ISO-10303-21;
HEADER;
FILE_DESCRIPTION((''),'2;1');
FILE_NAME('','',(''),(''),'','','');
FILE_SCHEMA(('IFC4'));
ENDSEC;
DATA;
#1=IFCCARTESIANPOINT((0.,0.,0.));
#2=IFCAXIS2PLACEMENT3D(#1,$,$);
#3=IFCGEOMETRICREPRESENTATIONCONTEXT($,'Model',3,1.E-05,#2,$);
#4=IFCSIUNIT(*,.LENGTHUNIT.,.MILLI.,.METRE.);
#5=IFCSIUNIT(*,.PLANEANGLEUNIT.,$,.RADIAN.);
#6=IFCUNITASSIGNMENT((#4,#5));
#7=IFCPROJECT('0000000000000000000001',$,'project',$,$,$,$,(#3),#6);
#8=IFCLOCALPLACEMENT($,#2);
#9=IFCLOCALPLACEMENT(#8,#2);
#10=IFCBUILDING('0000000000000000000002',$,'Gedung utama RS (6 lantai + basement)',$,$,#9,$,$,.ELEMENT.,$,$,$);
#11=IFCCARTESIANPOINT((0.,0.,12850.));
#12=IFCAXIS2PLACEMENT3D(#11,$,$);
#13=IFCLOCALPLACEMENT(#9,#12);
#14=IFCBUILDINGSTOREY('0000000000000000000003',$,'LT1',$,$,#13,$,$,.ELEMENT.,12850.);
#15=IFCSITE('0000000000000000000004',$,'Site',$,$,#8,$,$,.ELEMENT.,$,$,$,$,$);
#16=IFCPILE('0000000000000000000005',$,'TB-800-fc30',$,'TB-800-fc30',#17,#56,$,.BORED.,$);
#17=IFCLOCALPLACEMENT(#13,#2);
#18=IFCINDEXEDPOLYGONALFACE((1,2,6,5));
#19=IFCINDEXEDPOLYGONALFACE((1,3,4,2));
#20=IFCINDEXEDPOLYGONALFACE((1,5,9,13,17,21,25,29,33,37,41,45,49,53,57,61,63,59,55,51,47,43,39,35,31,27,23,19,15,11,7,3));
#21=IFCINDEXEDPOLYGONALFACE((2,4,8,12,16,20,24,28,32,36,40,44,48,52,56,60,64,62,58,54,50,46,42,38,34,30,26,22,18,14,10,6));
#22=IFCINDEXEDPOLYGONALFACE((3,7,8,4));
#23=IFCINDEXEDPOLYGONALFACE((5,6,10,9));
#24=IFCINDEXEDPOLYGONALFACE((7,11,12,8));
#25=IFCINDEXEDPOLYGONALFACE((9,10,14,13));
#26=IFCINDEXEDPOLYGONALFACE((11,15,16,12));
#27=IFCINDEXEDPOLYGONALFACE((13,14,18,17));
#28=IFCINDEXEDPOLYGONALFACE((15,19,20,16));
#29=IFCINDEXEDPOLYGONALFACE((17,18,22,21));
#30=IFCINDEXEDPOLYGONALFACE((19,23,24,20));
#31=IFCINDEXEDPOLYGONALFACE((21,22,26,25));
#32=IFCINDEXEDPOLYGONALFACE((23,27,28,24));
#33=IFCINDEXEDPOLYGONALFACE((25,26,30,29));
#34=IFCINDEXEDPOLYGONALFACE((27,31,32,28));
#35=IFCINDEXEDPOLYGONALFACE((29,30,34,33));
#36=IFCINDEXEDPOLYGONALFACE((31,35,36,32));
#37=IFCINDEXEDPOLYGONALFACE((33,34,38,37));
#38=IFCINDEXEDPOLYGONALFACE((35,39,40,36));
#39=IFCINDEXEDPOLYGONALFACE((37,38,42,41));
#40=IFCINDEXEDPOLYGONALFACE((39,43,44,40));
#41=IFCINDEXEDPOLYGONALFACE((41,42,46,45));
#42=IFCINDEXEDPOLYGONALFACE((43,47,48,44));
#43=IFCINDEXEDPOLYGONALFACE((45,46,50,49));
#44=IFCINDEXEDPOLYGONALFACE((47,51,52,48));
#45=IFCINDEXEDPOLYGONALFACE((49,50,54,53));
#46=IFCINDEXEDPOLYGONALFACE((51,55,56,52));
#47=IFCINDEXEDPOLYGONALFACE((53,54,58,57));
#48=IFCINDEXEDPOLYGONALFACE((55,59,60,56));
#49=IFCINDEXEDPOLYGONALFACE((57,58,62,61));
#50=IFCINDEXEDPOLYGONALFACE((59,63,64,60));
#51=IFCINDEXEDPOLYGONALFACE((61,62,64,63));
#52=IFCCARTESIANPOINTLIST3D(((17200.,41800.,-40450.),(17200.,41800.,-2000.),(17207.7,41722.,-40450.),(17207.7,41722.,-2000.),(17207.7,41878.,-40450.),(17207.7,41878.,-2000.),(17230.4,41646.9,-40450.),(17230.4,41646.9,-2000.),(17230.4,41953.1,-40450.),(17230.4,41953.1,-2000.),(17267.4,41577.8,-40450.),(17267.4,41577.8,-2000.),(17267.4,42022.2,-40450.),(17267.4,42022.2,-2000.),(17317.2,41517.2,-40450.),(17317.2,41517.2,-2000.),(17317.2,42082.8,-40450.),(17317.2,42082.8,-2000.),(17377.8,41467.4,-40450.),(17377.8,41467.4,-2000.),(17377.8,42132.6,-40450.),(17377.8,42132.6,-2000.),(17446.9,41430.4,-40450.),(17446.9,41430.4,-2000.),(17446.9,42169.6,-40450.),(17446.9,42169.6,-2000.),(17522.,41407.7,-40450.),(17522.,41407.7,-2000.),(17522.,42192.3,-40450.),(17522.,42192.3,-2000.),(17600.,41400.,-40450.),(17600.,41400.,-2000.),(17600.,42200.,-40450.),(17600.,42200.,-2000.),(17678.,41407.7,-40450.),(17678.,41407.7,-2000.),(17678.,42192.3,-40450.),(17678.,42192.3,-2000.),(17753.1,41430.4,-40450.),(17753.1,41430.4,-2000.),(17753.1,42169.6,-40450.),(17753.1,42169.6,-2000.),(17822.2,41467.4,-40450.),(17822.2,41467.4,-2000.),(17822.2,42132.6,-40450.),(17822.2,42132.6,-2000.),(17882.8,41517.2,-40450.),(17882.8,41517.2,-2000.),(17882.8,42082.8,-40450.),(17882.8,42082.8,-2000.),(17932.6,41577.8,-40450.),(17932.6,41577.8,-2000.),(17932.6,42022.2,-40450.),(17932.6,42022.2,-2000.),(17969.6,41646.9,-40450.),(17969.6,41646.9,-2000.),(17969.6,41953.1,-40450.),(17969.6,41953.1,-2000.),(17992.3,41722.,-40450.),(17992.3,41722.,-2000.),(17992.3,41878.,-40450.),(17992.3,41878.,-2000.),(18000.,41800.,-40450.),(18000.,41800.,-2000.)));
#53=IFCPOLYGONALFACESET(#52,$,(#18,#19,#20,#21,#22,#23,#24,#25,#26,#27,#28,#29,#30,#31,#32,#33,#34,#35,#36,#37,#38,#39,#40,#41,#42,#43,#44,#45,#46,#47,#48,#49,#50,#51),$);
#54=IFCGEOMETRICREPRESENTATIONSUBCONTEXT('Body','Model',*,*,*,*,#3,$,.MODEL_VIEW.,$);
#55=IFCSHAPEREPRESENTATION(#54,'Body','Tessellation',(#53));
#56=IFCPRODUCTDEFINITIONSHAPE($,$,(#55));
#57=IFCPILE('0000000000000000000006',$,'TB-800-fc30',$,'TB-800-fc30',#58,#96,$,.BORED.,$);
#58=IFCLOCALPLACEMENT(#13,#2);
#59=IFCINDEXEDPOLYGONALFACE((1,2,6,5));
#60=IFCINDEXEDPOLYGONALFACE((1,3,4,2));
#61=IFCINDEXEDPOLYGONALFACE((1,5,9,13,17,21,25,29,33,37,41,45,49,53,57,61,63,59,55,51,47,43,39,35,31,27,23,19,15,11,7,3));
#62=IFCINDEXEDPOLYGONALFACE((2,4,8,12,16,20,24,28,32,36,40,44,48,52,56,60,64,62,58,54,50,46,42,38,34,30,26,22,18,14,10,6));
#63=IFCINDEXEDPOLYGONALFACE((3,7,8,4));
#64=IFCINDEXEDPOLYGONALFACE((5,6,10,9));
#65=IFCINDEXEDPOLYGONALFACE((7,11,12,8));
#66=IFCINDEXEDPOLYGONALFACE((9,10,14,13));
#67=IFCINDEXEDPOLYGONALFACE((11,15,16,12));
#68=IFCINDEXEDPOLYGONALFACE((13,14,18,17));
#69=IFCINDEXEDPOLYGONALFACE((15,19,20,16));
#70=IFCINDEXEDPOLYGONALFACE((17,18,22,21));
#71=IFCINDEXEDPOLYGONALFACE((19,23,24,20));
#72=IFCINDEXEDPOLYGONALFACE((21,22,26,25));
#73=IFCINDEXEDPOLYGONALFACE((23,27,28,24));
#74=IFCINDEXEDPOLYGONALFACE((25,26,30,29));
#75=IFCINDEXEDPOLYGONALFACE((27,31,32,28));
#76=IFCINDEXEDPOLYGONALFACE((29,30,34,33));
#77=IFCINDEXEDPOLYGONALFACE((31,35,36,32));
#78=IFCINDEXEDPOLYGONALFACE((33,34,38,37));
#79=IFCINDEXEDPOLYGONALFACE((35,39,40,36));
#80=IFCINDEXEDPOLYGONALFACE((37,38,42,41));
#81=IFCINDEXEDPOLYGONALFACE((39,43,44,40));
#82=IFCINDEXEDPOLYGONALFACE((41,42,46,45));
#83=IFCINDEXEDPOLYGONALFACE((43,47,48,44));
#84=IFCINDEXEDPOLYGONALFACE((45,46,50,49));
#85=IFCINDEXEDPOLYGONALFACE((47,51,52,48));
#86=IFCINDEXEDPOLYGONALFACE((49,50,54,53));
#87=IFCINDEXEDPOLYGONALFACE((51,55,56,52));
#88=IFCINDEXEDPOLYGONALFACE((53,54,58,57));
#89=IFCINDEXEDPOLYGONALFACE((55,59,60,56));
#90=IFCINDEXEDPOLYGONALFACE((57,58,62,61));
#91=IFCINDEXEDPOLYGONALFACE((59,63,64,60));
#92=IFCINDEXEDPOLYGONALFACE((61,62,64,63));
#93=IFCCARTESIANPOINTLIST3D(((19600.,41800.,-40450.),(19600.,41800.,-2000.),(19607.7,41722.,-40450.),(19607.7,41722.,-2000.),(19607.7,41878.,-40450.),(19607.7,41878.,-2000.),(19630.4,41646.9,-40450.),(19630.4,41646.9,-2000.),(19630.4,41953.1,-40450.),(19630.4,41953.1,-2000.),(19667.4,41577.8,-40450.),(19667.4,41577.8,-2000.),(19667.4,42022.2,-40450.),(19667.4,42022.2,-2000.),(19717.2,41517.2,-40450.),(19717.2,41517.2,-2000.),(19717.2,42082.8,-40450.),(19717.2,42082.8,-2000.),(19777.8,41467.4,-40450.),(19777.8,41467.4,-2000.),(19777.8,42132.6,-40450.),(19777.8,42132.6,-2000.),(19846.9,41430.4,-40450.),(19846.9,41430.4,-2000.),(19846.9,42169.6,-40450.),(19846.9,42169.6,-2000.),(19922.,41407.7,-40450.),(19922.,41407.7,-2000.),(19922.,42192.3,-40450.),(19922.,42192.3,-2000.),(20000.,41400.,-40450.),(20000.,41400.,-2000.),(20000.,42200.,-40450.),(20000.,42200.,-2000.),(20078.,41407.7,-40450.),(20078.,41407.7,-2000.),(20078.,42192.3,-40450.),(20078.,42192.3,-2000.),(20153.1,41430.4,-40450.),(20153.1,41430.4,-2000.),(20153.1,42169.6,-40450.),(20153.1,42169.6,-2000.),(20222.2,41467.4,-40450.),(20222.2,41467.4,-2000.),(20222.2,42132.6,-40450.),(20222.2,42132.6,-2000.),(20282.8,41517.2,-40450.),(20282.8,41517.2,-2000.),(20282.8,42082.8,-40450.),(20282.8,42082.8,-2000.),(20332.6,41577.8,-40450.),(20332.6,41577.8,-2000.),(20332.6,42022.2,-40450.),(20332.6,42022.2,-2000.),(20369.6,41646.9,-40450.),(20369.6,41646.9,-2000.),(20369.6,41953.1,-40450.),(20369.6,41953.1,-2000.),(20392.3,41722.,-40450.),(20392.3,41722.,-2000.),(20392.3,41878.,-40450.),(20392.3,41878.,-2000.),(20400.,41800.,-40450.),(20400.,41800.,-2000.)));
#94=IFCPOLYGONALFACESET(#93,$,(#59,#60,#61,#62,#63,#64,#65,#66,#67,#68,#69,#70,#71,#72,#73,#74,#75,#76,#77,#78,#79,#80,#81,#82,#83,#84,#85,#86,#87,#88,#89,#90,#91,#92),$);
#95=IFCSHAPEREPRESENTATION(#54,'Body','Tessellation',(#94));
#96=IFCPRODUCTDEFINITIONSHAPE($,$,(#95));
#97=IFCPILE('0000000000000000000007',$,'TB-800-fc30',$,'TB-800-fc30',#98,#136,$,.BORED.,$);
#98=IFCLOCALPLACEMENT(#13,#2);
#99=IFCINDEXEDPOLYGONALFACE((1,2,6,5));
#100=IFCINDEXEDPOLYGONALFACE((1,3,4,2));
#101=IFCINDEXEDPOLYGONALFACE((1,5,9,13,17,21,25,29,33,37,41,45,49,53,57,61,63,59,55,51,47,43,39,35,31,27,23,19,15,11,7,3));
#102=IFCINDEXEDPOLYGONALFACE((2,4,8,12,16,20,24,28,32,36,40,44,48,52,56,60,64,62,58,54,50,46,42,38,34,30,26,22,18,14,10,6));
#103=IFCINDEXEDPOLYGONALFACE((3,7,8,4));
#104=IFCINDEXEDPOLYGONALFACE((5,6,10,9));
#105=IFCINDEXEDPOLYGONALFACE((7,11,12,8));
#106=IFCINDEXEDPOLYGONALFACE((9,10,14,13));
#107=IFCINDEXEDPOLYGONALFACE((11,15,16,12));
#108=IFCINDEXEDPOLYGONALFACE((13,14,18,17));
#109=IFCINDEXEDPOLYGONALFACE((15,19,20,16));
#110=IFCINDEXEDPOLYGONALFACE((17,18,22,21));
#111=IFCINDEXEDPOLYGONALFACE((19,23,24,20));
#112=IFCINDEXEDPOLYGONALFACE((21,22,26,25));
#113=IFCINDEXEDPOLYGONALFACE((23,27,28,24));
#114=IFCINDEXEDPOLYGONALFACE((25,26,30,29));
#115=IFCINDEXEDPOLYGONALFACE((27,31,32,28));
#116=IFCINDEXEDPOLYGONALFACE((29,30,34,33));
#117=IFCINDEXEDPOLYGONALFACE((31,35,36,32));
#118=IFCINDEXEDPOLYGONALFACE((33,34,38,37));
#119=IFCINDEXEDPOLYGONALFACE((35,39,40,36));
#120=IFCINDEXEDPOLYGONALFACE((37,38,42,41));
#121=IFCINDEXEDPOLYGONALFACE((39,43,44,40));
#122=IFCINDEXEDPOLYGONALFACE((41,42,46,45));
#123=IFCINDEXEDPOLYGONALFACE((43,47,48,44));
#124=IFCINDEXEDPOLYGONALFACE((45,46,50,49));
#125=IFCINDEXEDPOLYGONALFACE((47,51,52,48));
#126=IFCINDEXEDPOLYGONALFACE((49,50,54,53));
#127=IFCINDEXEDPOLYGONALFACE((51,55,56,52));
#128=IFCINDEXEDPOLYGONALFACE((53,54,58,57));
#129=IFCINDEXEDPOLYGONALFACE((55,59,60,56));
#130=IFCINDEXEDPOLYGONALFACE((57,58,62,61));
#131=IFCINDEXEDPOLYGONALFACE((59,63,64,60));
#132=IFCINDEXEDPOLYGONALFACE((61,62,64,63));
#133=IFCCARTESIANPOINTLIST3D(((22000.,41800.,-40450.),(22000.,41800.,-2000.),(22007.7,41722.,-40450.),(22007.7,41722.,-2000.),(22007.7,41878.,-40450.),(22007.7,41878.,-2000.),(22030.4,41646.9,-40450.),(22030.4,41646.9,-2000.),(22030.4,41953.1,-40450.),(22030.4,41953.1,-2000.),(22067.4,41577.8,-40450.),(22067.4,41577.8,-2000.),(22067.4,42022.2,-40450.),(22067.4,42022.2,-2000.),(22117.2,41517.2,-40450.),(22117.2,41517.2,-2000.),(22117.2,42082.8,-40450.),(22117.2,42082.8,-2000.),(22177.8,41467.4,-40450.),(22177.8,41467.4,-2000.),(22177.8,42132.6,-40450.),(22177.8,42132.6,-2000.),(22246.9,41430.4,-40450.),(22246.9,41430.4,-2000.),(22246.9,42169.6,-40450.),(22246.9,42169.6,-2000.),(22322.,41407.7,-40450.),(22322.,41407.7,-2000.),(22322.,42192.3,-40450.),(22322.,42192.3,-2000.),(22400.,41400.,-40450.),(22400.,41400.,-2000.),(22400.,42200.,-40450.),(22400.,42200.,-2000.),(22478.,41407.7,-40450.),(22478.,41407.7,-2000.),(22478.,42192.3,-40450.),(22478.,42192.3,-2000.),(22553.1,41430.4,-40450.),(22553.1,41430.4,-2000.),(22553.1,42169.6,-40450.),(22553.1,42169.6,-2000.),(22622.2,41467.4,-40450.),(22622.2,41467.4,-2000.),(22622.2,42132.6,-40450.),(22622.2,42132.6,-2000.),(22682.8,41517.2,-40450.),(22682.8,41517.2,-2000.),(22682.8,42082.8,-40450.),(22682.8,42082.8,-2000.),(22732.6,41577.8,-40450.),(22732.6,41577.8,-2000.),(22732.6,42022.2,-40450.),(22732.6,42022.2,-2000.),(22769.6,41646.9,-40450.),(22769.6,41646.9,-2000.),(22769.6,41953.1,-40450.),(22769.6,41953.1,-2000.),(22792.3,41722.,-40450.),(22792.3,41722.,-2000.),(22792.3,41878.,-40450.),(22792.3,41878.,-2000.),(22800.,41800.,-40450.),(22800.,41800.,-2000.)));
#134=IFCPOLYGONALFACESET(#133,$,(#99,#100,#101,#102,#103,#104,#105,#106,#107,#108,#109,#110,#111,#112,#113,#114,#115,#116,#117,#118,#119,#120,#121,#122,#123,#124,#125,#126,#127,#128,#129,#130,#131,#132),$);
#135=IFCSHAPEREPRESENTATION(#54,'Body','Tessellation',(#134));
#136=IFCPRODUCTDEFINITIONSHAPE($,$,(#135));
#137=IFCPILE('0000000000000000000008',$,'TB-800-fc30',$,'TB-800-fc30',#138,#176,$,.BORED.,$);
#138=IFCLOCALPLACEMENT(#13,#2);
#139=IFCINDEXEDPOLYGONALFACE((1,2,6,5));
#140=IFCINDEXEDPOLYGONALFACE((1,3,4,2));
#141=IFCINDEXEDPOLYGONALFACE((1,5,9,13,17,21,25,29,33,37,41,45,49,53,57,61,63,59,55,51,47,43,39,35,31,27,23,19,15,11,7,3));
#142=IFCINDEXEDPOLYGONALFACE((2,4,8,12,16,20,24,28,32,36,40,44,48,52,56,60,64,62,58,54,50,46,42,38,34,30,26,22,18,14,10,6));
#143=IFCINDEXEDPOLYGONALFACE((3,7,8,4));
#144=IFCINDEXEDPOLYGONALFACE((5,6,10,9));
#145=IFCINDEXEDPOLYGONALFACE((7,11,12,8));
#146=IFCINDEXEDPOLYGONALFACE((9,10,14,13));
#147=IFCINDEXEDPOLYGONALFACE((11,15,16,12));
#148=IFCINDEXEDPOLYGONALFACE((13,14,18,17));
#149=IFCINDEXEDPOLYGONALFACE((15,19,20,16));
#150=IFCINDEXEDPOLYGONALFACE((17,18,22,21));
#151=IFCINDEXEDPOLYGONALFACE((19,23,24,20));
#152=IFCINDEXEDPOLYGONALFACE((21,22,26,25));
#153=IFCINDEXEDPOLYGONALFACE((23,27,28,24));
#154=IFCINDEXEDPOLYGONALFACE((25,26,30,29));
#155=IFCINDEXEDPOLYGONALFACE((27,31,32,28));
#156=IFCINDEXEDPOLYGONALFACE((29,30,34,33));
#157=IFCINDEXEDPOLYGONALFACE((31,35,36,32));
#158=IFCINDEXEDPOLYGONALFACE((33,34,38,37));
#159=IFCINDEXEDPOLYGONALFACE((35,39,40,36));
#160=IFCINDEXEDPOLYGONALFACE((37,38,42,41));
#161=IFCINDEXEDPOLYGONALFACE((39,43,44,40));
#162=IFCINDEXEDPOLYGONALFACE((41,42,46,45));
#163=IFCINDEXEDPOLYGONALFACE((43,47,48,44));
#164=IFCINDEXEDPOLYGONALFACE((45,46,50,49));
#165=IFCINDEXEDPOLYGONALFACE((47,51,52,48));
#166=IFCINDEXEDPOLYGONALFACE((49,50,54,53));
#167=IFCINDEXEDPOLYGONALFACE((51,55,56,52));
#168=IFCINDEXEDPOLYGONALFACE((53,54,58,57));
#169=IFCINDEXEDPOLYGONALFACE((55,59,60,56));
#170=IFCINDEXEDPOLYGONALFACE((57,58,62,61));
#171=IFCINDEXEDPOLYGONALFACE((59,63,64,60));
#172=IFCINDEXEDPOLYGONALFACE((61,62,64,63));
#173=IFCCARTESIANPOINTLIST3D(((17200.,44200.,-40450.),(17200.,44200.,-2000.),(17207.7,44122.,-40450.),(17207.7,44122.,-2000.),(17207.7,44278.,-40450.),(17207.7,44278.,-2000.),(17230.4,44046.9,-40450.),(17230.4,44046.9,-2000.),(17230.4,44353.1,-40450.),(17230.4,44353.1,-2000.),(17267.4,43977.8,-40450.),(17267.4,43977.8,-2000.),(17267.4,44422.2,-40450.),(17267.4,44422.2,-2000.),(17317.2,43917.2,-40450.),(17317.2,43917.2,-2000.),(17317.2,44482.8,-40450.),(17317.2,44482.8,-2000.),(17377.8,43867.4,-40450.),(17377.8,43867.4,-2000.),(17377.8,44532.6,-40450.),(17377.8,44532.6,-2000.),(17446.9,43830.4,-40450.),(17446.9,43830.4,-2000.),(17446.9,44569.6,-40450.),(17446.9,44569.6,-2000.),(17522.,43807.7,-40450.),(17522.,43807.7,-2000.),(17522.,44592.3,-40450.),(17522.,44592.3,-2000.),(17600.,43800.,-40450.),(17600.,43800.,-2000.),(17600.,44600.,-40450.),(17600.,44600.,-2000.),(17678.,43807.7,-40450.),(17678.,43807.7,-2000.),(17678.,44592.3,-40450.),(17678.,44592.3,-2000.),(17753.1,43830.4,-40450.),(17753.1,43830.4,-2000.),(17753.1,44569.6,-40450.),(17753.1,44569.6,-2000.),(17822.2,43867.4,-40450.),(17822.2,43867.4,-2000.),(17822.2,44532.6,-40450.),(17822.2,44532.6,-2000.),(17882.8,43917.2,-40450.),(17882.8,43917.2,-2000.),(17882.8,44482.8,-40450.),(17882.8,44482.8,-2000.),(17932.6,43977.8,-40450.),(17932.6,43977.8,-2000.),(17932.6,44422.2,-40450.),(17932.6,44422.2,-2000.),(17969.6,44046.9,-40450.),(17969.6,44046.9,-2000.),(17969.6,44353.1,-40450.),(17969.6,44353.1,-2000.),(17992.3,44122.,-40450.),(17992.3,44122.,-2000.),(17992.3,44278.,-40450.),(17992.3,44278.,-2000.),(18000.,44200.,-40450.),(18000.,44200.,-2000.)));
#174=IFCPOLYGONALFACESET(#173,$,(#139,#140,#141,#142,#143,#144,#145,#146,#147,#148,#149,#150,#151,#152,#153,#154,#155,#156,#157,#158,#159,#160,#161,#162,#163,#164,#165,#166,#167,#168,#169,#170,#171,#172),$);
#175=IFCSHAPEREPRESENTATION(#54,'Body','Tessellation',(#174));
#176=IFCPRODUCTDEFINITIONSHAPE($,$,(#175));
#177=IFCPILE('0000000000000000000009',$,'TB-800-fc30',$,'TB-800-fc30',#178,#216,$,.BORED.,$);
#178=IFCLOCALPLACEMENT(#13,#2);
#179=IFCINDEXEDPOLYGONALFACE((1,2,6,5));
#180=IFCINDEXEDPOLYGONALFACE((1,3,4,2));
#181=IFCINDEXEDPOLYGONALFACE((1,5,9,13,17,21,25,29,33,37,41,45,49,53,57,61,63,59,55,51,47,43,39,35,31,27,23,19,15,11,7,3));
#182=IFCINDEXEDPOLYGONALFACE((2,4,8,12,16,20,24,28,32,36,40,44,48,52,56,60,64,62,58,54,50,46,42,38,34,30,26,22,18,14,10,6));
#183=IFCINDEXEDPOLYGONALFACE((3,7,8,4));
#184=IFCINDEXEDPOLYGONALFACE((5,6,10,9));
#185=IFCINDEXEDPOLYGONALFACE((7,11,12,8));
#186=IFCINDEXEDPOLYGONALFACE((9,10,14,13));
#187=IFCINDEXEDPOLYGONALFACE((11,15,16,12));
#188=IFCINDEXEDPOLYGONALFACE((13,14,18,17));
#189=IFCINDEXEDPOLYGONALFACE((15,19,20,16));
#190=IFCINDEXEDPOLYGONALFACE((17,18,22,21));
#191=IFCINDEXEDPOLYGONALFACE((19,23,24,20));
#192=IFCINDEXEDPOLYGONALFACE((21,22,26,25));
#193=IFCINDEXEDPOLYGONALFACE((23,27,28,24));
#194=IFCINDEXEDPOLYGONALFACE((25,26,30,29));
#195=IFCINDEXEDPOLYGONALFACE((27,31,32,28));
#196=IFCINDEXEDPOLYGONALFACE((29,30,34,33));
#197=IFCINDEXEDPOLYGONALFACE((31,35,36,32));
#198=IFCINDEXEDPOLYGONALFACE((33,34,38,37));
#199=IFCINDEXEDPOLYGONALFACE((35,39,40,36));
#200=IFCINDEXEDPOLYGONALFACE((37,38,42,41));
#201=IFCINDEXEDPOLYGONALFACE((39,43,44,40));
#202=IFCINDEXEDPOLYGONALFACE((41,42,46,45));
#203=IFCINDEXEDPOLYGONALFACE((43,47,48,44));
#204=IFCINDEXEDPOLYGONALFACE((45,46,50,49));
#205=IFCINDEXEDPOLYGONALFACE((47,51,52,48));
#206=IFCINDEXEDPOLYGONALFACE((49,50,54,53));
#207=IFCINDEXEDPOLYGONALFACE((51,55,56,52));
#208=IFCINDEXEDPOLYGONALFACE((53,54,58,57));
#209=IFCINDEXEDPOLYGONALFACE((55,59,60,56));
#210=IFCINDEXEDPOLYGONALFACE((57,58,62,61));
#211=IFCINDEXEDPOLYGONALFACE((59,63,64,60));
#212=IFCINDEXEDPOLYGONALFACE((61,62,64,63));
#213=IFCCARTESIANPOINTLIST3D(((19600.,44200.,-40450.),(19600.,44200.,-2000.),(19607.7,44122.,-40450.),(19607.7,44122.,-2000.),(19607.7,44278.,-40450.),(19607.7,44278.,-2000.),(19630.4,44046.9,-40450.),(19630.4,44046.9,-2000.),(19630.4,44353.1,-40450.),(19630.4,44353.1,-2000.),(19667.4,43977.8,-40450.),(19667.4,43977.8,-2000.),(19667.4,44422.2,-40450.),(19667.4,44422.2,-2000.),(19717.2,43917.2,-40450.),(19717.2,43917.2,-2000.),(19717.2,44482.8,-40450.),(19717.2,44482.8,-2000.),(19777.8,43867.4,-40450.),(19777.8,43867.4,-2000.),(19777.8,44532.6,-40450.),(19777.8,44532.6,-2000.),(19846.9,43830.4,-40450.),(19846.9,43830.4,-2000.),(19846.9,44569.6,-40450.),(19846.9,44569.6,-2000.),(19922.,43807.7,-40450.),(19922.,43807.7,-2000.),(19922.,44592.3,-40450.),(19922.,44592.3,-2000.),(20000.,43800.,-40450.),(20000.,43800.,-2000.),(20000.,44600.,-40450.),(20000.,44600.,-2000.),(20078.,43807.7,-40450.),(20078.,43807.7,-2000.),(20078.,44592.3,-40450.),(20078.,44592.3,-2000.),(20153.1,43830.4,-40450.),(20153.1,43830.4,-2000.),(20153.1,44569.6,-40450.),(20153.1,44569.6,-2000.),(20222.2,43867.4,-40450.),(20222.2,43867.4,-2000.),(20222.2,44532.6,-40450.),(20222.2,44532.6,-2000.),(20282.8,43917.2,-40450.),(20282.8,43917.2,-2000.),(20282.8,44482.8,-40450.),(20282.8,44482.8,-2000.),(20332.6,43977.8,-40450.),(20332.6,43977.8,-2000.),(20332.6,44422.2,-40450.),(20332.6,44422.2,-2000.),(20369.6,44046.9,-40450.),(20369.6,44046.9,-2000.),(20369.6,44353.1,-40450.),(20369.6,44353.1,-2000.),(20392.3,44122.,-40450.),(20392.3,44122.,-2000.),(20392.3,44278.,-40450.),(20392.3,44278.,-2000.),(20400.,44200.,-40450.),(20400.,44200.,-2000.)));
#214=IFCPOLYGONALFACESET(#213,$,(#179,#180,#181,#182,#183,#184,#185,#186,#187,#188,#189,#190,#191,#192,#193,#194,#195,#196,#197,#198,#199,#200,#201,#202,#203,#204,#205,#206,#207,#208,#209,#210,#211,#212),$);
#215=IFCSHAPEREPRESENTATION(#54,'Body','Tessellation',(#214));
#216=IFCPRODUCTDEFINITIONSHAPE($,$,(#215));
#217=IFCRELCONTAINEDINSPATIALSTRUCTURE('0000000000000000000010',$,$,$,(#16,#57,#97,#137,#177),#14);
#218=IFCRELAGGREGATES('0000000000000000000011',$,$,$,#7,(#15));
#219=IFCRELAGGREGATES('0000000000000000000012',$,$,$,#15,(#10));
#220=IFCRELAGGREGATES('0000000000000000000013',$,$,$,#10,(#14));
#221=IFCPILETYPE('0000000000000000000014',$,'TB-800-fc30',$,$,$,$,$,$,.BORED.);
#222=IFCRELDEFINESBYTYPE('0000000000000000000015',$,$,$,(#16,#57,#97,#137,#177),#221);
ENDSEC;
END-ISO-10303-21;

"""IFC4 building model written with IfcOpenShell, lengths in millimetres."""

from ifc_helpers import new_model, si_unit, frame, origin, origin_2d, place, context, subcontext, project, spatial, circle, extrude, material_profile, profile_set, profile_usage, type_object, element, save


model = new_model("IFC4")

# Units and contexts
model_context = context("Model", 3, precision=1e-05, world=origin())
body_context = subcontext(model_context, "Body", "Model", "MODEL_VIEW")
ifc_project = project(units=[si_unit("LENGTHUNIT", "METRE", prefix="MILLI"), si_unit("PLANEANGLEUNIT", "RADIAN")], contexts=[model_context])

# Site, building, storey
site_placement = place(None, origin())
site = spatial("IfcSite", under=ifc_project, at=site_placement, Name="Site", CompositionType="ELEMENT")
building_placement = place(site_placement, origin())
building = spatial("IfcBuilding", under=site, at=building_placement, Name="Gedung utama RS (6 lantai + basement)", CompositionType="ELEMENT")
storey_placement = place(building_placement, frame((0.0, 0.0, 12850.0)))
storey = spatial("IfcBuildingStorey", under=building, at=storey_placement, Name="LT1", CompositionType="ELEMENT", Elevation=12850.0)

# Piles
ifc_material_profile_1 = material_profile(None, circle(Radius=400.0, at=origin_2d()), Name="TB-800-fc30")
ifc_profile_set_1 = profile_set([ifc_material_profile_1], Name="TB-800-fc30")
ifc_profile_usage_1 = profile_usage(ifc_profile_set_1, cardinal=5)
pile_type = type_object("IfcPileType", Name="TB-800-fc30", PredefinedType="BORED", material=ifc_profile_set_1)
for number, where, z_axis, x_axis, name in (
    (1, (17600.0, 41800.0, -40450.0), (0.0, 0.0, 1.0), (1.0, 0.0, 0.0), "TB-800-fc30"),
    (2, (20000.0, 41800.0, -40450.0), (0.0, 0.0, 1.0), (1.0, 0.0, 0.0), "TB-800-fc30"),
    (3, (22400.0, 41800.0, -40450.0), (0.0, 0.0, 1.0), (1.0, 0.0, 0.0), "TB-800-fc30"),
    (4, (17600.0, 44200.0, -40450.0), (0.0, 0.0, 1.0), (1.0, 0.0, 0.0), "TB-800-fc30"),
    (5, (20000.0, 44200.0, -40450.0), (0.0, 0.0, 1.0), (1.0, 0.0, 0.0), "TB-800-fc30"),
):
    element("IfcPile", number, at=place(storey_placement, frame(where, z_axis=z_axis, x_axis=x_axis)), inside=storey, type_object=pile_type, material=ifc_profile_usage_1, Name=name, ObjectType="TB-800-fc30", PredefinedType="BORED", context=body_context, shape_type="SweptSolid", body=[
        extrude(circle(Radius=400.0, at=origin_2d()), origin(), (0.0, 0.0, 1.0), 38450.0),
    ])

save(model, "model.ifc")
